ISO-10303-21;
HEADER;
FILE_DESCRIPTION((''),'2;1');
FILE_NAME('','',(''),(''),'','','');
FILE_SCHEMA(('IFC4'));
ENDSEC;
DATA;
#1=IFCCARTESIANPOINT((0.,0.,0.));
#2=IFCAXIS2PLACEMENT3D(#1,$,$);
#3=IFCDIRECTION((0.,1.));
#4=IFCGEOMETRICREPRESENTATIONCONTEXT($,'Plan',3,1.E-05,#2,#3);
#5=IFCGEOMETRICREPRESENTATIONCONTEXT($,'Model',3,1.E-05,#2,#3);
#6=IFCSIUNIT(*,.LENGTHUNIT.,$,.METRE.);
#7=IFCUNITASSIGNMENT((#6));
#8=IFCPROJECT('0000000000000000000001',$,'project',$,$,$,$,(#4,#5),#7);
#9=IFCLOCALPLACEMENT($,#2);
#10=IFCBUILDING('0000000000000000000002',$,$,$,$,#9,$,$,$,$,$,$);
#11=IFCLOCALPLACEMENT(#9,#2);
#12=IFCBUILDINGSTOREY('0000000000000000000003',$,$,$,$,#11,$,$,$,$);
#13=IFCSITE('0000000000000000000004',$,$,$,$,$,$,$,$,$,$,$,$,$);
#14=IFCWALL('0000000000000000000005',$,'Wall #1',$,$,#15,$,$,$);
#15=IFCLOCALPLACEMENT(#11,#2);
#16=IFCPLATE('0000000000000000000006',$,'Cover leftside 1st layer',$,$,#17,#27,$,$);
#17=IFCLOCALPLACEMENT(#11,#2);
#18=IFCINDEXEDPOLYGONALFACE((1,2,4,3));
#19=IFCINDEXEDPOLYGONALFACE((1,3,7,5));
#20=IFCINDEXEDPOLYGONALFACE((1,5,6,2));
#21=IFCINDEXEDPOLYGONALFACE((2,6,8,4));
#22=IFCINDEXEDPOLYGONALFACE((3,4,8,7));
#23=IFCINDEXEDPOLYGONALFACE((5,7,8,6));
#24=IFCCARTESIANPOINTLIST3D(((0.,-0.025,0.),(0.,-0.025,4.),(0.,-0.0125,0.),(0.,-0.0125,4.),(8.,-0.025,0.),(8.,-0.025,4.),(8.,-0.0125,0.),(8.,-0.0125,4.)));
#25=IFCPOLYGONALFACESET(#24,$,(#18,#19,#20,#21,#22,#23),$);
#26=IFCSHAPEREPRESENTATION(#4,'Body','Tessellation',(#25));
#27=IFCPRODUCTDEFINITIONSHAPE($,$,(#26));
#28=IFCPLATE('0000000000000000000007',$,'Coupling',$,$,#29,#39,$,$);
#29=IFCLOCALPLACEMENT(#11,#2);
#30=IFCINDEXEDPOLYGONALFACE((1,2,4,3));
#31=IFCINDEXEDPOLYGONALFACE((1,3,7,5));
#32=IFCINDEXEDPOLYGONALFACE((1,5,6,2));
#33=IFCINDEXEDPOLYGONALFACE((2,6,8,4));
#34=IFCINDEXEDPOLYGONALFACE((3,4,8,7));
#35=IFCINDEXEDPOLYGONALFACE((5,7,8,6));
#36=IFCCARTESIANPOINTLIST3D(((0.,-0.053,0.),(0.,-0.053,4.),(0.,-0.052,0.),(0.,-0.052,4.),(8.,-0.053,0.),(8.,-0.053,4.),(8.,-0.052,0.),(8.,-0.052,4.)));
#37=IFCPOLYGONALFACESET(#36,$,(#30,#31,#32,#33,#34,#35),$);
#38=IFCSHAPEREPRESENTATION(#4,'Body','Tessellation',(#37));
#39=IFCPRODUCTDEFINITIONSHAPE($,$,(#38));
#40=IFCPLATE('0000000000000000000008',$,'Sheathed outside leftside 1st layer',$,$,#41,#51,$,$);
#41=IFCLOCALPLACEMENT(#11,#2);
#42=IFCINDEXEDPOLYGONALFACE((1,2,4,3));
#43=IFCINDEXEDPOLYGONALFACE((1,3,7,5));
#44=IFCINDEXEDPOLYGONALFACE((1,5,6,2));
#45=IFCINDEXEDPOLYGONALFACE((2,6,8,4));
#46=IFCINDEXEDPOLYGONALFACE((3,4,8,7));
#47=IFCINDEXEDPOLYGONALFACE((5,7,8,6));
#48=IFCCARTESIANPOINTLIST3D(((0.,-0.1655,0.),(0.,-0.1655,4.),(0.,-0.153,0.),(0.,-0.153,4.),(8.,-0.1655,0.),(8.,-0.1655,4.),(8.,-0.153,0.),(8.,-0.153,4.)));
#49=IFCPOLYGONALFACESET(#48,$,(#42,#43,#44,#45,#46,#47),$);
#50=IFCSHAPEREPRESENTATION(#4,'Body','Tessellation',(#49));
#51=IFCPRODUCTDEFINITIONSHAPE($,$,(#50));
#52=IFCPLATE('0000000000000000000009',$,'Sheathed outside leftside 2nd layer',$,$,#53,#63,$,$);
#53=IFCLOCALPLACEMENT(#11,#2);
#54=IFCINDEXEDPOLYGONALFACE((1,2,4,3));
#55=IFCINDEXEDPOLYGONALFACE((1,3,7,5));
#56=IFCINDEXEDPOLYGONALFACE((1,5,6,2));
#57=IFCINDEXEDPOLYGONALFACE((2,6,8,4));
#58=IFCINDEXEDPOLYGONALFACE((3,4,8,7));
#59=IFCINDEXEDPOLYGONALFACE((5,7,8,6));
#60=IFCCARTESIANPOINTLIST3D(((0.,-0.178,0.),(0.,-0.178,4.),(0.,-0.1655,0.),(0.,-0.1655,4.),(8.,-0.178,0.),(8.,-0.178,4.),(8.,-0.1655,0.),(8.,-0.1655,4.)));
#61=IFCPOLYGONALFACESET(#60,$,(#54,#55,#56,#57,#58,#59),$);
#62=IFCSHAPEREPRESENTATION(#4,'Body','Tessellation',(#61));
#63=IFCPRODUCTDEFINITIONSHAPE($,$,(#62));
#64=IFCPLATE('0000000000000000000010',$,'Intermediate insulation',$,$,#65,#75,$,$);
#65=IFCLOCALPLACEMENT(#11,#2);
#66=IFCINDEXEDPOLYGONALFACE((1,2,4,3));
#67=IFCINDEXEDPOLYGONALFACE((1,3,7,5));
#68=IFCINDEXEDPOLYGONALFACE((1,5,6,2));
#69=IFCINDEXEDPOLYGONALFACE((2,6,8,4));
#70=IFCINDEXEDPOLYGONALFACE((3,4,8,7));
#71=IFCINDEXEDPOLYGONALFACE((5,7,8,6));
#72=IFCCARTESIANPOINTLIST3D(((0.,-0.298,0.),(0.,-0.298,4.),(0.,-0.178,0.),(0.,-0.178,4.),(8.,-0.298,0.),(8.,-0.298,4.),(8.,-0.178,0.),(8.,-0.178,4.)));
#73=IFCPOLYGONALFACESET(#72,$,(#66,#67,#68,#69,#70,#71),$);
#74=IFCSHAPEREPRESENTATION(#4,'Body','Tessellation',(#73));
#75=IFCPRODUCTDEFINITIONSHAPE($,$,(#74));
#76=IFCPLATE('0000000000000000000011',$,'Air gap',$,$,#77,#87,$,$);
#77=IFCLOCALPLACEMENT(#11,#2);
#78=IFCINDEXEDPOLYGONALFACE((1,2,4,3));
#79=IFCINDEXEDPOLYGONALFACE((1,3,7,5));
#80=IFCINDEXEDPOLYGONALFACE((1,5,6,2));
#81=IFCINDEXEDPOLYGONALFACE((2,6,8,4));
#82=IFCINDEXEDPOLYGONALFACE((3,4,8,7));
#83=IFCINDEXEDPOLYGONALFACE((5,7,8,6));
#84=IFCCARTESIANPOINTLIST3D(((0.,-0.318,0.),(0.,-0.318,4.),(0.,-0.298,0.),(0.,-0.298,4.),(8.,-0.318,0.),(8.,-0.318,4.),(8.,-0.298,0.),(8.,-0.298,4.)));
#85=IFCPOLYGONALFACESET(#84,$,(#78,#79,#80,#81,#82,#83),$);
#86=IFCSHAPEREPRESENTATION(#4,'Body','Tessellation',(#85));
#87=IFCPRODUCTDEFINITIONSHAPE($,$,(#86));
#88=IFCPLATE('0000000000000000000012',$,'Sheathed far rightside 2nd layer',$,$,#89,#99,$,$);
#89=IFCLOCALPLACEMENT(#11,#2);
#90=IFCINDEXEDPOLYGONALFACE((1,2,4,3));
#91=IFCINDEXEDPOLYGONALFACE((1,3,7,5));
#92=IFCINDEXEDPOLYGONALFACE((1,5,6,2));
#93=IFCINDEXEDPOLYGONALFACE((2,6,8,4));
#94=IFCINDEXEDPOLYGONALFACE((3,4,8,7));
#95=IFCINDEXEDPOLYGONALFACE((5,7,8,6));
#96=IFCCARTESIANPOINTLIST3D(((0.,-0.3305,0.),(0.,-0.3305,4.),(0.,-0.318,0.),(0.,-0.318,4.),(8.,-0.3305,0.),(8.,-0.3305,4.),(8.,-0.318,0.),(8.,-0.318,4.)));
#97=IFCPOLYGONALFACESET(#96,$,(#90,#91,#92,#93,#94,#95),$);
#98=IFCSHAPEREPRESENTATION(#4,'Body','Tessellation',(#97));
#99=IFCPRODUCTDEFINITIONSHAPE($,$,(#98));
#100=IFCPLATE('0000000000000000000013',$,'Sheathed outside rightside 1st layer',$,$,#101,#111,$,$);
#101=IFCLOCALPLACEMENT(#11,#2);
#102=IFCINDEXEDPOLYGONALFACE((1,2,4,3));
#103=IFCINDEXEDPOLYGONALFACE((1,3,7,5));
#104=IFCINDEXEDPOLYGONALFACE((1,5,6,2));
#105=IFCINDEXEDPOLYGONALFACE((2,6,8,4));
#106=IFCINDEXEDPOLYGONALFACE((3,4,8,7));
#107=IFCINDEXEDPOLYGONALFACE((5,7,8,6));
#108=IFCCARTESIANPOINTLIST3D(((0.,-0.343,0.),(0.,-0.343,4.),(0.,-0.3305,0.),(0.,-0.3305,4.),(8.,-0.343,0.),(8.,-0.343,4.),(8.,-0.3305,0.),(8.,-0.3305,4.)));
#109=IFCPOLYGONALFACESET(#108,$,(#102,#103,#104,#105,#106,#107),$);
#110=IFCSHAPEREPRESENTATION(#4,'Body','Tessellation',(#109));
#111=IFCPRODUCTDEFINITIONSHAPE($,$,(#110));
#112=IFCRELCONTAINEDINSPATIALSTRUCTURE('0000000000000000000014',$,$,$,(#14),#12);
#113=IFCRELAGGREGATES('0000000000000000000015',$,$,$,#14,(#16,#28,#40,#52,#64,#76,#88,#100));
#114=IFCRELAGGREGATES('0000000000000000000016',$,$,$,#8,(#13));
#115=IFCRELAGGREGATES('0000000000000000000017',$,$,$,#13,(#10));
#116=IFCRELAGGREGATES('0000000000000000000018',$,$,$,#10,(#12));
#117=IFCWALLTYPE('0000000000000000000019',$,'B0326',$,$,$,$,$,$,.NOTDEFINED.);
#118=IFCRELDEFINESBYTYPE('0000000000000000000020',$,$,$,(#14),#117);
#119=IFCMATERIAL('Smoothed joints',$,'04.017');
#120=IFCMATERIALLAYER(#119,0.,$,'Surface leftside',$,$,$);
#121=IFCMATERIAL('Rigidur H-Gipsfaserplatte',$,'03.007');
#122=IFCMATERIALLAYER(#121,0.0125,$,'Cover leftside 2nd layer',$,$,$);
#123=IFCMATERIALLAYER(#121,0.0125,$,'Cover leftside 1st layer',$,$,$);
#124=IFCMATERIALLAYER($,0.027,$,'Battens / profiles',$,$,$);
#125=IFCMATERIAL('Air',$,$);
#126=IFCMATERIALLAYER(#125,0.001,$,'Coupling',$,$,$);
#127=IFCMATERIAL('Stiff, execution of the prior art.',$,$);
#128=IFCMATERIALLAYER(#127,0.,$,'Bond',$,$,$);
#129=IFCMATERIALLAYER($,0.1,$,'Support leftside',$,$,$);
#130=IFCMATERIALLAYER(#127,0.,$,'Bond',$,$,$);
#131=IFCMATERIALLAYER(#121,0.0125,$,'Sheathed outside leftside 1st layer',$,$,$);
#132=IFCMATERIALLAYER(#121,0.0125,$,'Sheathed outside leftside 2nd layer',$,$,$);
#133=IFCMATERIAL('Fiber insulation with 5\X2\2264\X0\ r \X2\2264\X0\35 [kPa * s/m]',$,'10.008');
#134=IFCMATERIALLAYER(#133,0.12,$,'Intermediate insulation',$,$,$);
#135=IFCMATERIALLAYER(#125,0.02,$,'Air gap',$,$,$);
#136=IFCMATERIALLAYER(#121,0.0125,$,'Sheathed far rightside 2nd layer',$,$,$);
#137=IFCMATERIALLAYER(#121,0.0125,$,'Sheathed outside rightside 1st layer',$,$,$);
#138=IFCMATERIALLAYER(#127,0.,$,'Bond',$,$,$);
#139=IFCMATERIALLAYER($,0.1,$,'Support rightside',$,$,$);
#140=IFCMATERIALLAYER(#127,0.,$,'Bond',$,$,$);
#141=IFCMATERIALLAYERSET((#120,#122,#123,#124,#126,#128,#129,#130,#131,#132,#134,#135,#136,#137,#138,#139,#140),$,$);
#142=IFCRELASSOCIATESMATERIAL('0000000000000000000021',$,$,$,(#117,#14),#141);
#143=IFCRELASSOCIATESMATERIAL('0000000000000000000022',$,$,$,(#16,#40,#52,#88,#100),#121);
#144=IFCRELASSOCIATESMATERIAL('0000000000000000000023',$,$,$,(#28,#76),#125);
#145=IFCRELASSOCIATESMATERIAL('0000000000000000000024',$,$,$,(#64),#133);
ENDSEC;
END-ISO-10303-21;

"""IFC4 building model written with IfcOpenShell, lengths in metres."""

from ifc_helpers import new_model, si_unit, direction, frame, frame_2d, origin, place, context, project, spatial, rectangle, extrude, material, layer, layer_set, type_object, element, aggregate, save


model = new_model("IFC4")

# Units and contexts
plan_context = context("Plan", 3, precision=1e-05, world=origin(), true_north=direction((0.0, 1.0)))
model_context = context("Model", 3, precision=1e-05, world=origin(), true_north=direction((0.0, 1.0)))
ifc_project = project(units=[si_unit("LENGTHUNIT", "METRE")], contexts=[plan_context, model_context])

# Site, building, storey
site = spatial("IfcSite", under=ifc_project)
building_placement = place(None, origin())
building = spatial("IfcBuilding", under=site, at=building_placement)
storey_placement = place(building_placement, origin())
storey = spatial("IfcBuildingStorey", under=building, at=storey_placement)

# Wall, plates
ifc_material_1 = material(Name="Smoothed joints", Category="04.017")
ifc_layer_1 = layer(ifc_material_1, 0.0, Name="Surface leftside")
ifc_material_2 = material(Name="Rigidur H-Gipsfaserplatte", Category="03.007")
ifc_layer_2 = layer(ifc_material_2, 0.0125, Name="Cover leftside 2nd layer")
ifc_layer_3 = layer(ifc_material_2, 0.0125, Name="Cover leftside 1st layer")
ifc_layer_4 = layer(None, 0.027, Name="Battens / profiles")
ifc_material_3 = material(Name="Air")
ifc_layer_5 = layer(ifc_material_3, 0.001, Name="Coupling")
ifc_material_4 = material(Name="Stiff, execution of the prior art.")
ifc_layer_6 = layer(ifc_material_4, 0.0, Name="Bond")
ifc_layer_7 = layer(None, 0.1, Name="Support leftside")
ifc_layer_8 = layer(ifc_material_4, 0.0, Name="Bond")
ifc_layer_9 = layer(ifc_material_2, 0.0125, Name="Sheathed outside leftside 1st layer")
ifc_layer_10 = layer(ifc_material_2, 0.0125, Name="Sheathed outside leftside 2nd layer")
ifc_material_5 = material(Name="Fiber insulation with 5≤ r ≤35 [kPa * s/m]", Category="10.008")
ifc_layer_11 = layer(ifc_material_5, 0.12, Name="Intermediate insulation")
ifc_layer_12 = layer(ifc_material_3, 0.02, Name="Air gap")
ifc_layer_13 = layer(ifc_material_2, 0.0125, Name="Sheathed far rightside 2nd layer")
ifc_layer_14 = layer(ifc_material_2, 0.0125, Name="Sheathed outside rightside 1st layer")
ifc_layer_15 = layer(ifc_material_4, 0.0, Name="Bond")
ifc_layer_16 = layer(None, 0.1, Name="Support rightside")
ifc_layer_17 = layer(ifc_material_4, 0.0, Name="Bond")
ifc_layer_set = layer_set([ifc_layer_1, ifc_layer_2, ifc_layer_3, ifc_layer_4, ifc_layer_5, ifc_layer_6, ifc_layer_7, ifc_layer_8, ifc_layer_9, ifc_layer_10, ifc_layer_11, ifc_layer_12, ifc_layer_13, ifc_layer_14, ifc_layer_15, ifc_layer_16, ifc_layer_17])
wall_type = type_object("IfcWallType", Name="B0326", PredefinedType="NOTDEFINED", material=ifc_layer_set)
wall_placement = place(None, frame((0.0, 0.0, 0.0), z_axis=(0.0, -1.0, 0.0), x_axis=(1.0, 0.0, 0.0)))
wall = element("IfcWall", 1, at=wall_placement, inside=storey, type_object=wall_type, material=ifc_layer_set, Name="Wall #1")
plate_1_placement = place(wall_placement, origin())
plate_1 = element("IfcPlate", 2, at=plate_1_placement, material=ifc_material_2, Name="Cover leftside 1st layer", context=plan_context, shape_type="SweptSolid", body=[
    extrude(rectangle(XDim=8.0, YDim=4.0, at=frame_2d((4.0, 2.0), x_axis=(1.0, 0.0))), frame((0.0, 0.0, 0.0125), z_axis=(0.0, 0.0, 1.0), x_axis=(1.0, 0.0, 0.0)), (0.0, 0.0, 1.0), 0.0125),
])
plate_2_placement = place(wall_placement, origin())
plate_2 = element("IfcPlate", 3, at=plate_2_placement, material=ifc_material_3, Name="Coupling", context=plan_context, shape_type="SweptSolid", body=[
    extrude(rectangle(XDim=8.0, YDim=4.0, at=frame_2d((4.0, 2.0), x_axis=(1.0, 0.0))), frame((0.0, 0.0, 0.052), z_axis=(0.0, 0.0, 1.0), x_axis=(1.0, 0.0, 0.0)), (0.0, 0.0, 1.0), 0.001),
])
plate_3_placement = place(wall_placement, origin())
plate_3 = element("IfcPlate", 4, at=plate_3_placement, material=ifc_material_2, Name="Sheathed outside leftside 1st layer", context=plan_context, shape_type="SweptSolid", body=[
    extrude(rectangle(XDim=8.0, YDim=4.0, at=frame_2d((4.0, 2.0), x_axis=(1.0, 0.0))), frame((0.0, 0.0, 0.153), z_axis=(0.0, 0.0, 1.0), x_axis=(1.0, 0.0, 0.0)), (0.0, 0.0, 1.0), 0.0125),
])
plate_4_placement = place(wall_placement, origin())
plate_4 = element("IfcPlate", 5, at=plate_4_placement, material=ifc_material_2, Name="Sheathed outside leftside 2nd layer", context=plan_context, shape_type="SweptSolid", body=[
    extrude(rectangle(XDim=8.0, YDim=4.0, at=frame_2d((4.0, 2.0), x_axis=(1.0, 0.0))), frame((0.0, 0.0, 0.1655), z_axis=(0.0, 0.0, 1.0), x_axis=(1.0, 0.0, 0.0)), (0.0, 0.0, 1.0), 0.0125),
])
plate_5_placement = place(wall_placement, origin())
plate_5 = element("IfcPlate", 6, at=plate_5_placement, material=ifc_material_5, Name="Intermediate insulation", context=plan_context, shape_type="SweptSolid", body=[
    extrude(rectangle(XDim=8.0, YDim=4.0, at=frame_2d((4.0, 2.0), x_axis=(1.0, 0.0))), frame((0.0, 0.0, 0.178), z_axis=(0.0, 0.0, 1.0), x_axis=(1.0, 0.0, 0.0)), (0.0, 0.0, 1.0), 0.12),
])
plate_6_placement = place(wall_placement, origin())
plate_6 = element("IfcPlate", 7, at=plate_6_placement, material=ifc_material_3, Name="Air gap", context=plan_context, shape_type="SweptSolid", body=[
    extrude(rectangle(XDim=8.0, YDim=4.0, at=frame_2d((4.0, 2.0), x_axis=(1.0, 0.0))), frame((0.0, 0.0, 0.298), z_axis=(0.0, 0.0, 1.0), x_axis=(1.0, 0.0, 0.0)), (0.0, 0.0, 1.0), 0.02),
])
plate_7_placement = place(wall_placement, origin())
plate_7 = element("IfcPlate", 8, at=plate_7_placement, material=ifc_material_2, Name="Sheathed far rightside 2nd layer", context=plan_context, shape_type="SweptSolid", body=[
    extrude(rectangle(XDim=8.0, YDim=4.0, at=frame_2d((4.0, 2.0), x_axis=(1.0, 0.0))), frame((0.0, 0.0, 0.318), z_axis=(0.0, 0.0, 1.0), x_axis=(1.0, 0.0, 0.0)), (0.0, 0.0, 1.0), 0.0125),
])
plate_8_placement = place(wall_placement, origin())
plate_8 = element("IfcPlate", 9, at=plate_8_placement, material=ifc_material_2, Name="Sheathed outside rightside 1st layer", context=plan_context, shape_type="SweptSolid", body=[
    extrude(rectangle(XDim=8.0, YDim=4.0, at=frame_2d((4.0, 2.0), x_axis=(1.0, 0.0))), frame((0.0, 0.0, 0.3305), z_axis=(0.0, 0.0, 1.0), x_axis=(1.0, 0.0, 0.0)), (0.0, 0.0, 1.0), 0.0125),
])
aggregate(wall, [plate_1, plate_2, plate_3, plate_4, plate_5, plate_6, plate_7, plate_8])

save(model, "model.ifc")
